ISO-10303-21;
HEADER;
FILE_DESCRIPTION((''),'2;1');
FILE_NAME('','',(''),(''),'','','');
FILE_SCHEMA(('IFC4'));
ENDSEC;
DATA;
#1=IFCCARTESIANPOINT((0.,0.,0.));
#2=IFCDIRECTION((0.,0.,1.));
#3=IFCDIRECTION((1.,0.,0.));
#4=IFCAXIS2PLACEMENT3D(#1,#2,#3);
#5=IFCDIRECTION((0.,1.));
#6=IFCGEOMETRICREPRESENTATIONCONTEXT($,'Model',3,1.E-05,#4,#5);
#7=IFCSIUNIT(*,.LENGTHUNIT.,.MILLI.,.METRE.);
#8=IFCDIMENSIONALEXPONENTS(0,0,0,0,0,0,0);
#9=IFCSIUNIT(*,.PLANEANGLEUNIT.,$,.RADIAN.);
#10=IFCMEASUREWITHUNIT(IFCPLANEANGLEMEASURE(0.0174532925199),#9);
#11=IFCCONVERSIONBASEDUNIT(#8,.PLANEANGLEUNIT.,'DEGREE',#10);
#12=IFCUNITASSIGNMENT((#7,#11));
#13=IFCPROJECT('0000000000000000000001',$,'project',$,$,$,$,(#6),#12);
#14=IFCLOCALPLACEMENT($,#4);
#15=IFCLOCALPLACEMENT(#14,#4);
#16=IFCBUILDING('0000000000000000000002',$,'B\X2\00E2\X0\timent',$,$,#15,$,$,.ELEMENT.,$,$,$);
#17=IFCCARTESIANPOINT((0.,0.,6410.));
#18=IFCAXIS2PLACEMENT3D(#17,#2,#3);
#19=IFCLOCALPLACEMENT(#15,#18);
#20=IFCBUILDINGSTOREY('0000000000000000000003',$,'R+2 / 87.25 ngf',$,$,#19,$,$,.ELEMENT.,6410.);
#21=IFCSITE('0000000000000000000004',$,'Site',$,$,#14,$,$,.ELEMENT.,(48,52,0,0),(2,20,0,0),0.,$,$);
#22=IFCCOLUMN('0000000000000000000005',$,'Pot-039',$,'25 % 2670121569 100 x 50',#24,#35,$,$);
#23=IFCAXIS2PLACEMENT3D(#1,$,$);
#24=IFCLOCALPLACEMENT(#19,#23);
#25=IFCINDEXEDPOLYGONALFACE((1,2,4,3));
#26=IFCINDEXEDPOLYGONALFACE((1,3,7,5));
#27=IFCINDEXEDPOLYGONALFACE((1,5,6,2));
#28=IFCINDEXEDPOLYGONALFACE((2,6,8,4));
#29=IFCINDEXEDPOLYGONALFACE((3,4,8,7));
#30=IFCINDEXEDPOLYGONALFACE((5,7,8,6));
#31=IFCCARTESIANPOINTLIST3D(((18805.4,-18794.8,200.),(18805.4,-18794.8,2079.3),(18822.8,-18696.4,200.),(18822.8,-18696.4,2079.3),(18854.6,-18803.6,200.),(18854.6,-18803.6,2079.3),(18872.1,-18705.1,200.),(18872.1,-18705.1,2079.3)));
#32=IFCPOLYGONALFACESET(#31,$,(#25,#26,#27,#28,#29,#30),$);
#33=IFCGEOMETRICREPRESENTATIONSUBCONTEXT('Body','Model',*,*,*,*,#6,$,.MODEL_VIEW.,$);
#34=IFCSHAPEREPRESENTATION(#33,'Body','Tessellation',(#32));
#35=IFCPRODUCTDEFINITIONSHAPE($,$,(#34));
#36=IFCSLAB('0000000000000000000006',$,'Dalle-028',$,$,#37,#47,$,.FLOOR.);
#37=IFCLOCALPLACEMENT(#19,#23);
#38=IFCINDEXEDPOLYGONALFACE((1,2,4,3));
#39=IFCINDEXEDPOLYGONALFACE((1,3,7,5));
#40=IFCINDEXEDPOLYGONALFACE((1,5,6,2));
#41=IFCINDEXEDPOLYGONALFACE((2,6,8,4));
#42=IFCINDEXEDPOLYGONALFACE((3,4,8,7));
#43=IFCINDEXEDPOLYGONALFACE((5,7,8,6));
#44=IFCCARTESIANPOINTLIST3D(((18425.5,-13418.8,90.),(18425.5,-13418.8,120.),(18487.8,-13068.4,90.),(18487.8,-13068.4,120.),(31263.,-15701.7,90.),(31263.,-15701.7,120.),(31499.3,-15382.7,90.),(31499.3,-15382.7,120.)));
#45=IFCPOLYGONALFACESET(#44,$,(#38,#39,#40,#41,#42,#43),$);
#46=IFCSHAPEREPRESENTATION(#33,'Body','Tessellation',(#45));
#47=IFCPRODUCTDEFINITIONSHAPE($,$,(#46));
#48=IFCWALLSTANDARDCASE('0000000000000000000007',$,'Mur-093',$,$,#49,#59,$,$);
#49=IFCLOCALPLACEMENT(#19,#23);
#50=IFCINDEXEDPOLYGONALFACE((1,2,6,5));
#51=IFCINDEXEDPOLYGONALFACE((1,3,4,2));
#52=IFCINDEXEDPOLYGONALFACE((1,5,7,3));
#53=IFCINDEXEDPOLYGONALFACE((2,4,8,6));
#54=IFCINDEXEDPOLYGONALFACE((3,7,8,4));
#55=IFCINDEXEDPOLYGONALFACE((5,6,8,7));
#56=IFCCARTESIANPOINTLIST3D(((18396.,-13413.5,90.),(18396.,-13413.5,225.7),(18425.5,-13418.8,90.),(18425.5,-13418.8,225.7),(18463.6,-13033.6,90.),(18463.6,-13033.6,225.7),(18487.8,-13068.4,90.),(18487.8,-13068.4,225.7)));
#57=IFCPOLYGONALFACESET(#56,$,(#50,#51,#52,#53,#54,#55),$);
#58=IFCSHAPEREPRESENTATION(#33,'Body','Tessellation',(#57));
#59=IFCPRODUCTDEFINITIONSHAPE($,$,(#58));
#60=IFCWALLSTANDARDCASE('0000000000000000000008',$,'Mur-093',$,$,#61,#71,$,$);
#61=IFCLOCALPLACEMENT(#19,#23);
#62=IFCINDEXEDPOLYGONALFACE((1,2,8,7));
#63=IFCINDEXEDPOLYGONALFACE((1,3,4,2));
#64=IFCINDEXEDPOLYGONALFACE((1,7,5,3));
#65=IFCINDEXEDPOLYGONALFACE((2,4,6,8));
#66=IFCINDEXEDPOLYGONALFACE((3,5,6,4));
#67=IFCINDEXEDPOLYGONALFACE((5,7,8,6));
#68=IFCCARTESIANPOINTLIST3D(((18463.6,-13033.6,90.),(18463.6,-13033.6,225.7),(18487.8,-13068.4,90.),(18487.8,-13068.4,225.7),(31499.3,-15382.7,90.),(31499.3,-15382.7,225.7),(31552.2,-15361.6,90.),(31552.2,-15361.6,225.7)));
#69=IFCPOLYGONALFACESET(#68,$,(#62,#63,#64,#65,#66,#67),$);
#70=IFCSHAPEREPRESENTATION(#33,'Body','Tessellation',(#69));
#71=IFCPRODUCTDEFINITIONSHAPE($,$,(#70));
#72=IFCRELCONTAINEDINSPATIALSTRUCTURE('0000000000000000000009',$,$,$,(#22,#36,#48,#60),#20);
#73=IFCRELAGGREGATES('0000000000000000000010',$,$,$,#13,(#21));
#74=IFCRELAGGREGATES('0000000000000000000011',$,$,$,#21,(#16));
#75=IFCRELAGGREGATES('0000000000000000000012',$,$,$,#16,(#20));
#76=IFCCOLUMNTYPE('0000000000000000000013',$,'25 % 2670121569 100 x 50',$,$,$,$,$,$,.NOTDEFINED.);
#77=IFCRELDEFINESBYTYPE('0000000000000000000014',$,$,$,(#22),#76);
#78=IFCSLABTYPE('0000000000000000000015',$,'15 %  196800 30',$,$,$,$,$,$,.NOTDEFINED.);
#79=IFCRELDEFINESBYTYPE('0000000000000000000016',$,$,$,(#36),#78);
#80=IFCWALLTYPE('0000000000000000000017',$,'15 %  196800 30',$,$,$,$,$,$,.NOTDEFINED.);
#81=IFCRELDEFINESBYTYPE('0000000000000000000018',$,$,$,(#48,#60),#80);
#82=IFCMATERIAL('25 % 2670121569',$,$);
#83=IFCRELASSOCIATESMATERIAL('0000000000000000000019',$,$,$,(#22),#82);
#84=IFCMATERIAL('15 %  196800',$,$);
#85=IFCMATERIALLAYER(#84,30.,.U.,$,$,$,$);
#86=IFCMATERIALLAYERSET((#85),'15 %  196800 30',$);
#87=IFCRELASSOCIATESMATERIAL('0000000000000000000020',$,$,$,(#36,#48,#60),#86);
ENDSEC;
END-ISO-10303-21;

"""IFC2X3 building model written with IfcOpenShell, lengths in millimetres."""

from ifc_helpers import new_model, entity, si_unit, converted_unit, direction, frame, origin_with_axes, origin_2d_with_axis, place, context, subcontext, project, spatial, polyline, rectangle, outline, extrude, material, layer, layer_set, layer_usage, type_object, element, save


model = new_model("IFC2X3")

# Units and contexts
model_context = context("Model", 3, precision=1e-05, world=origin_with_axes(), true_north=direction((0.0, 1.0)))
body_context = subcontext(model_context, "Body", "Model", "MODEL_VIEW")
ifc_project = project(units=[si_unit("LENGTHUNIT", "METRE", prefix="MILLI"), converted_unit("PLANEANGLEUNIT", "DEGREE", entity("IfcPlaneAngleMeasure", 0.0174532925199), si_unit("PLANEANGLEUNIT", "RADIAN"), dimensions=[0, 0, 0, 0, 0, 0, 0])], contexts=[model_context])

# Site, building, storey
site_placement = place(None, origin_with_axes())
site = spatial("IfcSite", under=ifc_project, at=site_placement, Name="Site", CompositionType="ELEMENT", RefLatitude=(48, 52, 0, 0), RefLongitude=(2, 20, 0, 0), RefElevation=0.0)
building_placement = place(site_placement, origin_with_axes())
building = spatial("IfcBuilding", under=site, at=building_placement, Name="Bâtiment", CompositionType="ELEMENT")
storey_placement = place(building_placement, frame((0.0, 0.0, 6410.0), z_axis=(0.0, 0.0, 1.0), x_axis=(1.0, 0.0, 0.0)))
storey = spatial("IfcBuildingStorey", under=building, at=storey_placement, Name="R+2 / 87.25 ngf", CompositionType="ELEMENT", Elevation=6410.0)

# Column
ifc_material_1 = material(Name="25 % 2670121569")
column_type = type_object("IfcColumnType", Name="25 % 2670121569 100 x 50", PredefinedType="NOTDEFINED")
column_1_placement = place(storey_placement, frame((18838.7, -18750.0, 200.0), z_axis=(0.0, 0.0, 1.0), x_axis=(0.17478, 0.984607, 0.0)))
element("IfcColumn", 1, at=column_1_placement, inside=storey, type_object=column_type, material=ifc_material_1, Name="Pot-039", ObjectType="25 % 2670121569 100 x 50", context=body_context, shape_type="SweptSolid", body=[
    extrude(rectangle(XDim=100.0, YDim=50.0, at=origin_2d_with_axis()), origin_with_axes(), (0.0, 0.0, 1.0), 1879.3),
])

# Slab
ifc_material_2 = material(Name="15 %  196800")
ifc_layer_1 = layer(ifc_material_2, 30.0, ventilated="UNKNOWN")
ifc_layer_set_1 = layer_set([ifc_layer_1], Name="15 %  196800 30")
ifc_layer_usage_1 = layer_usage(ifc_layer_set_1, "AXIS3", "NEGATIVE", 30.0)
slab_type_1 = type_object("IfcSlabType", Name="15 %  196800 30", PredefinedType="NOTDEFINED")
slab_1_placement = place(storey_placement, frame((18487.8, -13068.4, 120.0), z_axis=(0.0, 0.0, 1.0), x_axis=(1.0, 0.0, 0.0)))
element("IfcSlab", 2, at=slab_1_placement, inside=storey, type_object=slab_type_1, material=ifc_layer_usage_1, Name="Dalle-028", PredefinedType="FLOOR", context=body_context, shape_type="SweptSolid", body=[
    extrude(outline(polyline([(0.0, 0.0), (-62.3, -350.3), (12775.1, -2633.3), (13011.5, -2314.2), (0.0, 0.0)])), frame((0.0, 0.0, -30.0), z_axis=(0.0, 0.0, 1.0), x_axis=(1.0, 0.0, 0.0)), (0.0, 0.0, 1.0), 30.0),
])

# Walls
ifc_layer_usage_2 = layer_usage(ifc_layer_set_1, "AXIS2", "POSITIVE", -30.0)
wall_type_1 = type_object("IfcWallType", Name="15 %  196800 30", PredefinedType="NOTDEFINED")
wall_1_placement = place(storey_placement, frame((18487.8, -13068.4, 90.0), z_axis=(0.0, 0.0, 1.0), x_axis=(-0.175083, -0.984554, 0.0)))
element("IfcWallStandardCase", 3, at=wall_1_placement, inside=storey, type_object=wall_type_1, material=ifc_layer_usage_2, Name="Mur-093", context=body_context, shape_type="SweptSolid", body=[
    extrude(outline(polyline([(-30.0, -30.0), (355.8, -30.0), (355.8, 0.0), (0.0, 0.0), (-30.0, -30.0)])), origin_with_axes(), (0.0, 0.0, 1.0), 135.7),
])
ifc_layer_usage_3 = layer_usage(ifc_layer_set_1, "AXIS2", "NEGATIVE", 30.0)
wall_2_placement = place(storey_placement, frame((18487.8, -13068.4, 90.0), z_axis=(0.0, 0.0, 1.0), x_axis=(0.984548, -0.175113, 0.0)))
element("IfcWallStandardCase", 4, at=wall_2_placement, inside=storey, type_object=wall_type_1, material=ifc_layer_usage_3, Name="Mur-093", context=body_context, shape_type="SweptSolid", body=[
    extrude(outline(polyline([(0.0, 0.0), (13215.7, 0.0), (13264.1, 30.0), (-30.0, 30.0), (0.0, 0.0)])), origin_with_axes(), (0.0, 0.0, 1.0), 135.7),
])

save(model, "model.ifc")
